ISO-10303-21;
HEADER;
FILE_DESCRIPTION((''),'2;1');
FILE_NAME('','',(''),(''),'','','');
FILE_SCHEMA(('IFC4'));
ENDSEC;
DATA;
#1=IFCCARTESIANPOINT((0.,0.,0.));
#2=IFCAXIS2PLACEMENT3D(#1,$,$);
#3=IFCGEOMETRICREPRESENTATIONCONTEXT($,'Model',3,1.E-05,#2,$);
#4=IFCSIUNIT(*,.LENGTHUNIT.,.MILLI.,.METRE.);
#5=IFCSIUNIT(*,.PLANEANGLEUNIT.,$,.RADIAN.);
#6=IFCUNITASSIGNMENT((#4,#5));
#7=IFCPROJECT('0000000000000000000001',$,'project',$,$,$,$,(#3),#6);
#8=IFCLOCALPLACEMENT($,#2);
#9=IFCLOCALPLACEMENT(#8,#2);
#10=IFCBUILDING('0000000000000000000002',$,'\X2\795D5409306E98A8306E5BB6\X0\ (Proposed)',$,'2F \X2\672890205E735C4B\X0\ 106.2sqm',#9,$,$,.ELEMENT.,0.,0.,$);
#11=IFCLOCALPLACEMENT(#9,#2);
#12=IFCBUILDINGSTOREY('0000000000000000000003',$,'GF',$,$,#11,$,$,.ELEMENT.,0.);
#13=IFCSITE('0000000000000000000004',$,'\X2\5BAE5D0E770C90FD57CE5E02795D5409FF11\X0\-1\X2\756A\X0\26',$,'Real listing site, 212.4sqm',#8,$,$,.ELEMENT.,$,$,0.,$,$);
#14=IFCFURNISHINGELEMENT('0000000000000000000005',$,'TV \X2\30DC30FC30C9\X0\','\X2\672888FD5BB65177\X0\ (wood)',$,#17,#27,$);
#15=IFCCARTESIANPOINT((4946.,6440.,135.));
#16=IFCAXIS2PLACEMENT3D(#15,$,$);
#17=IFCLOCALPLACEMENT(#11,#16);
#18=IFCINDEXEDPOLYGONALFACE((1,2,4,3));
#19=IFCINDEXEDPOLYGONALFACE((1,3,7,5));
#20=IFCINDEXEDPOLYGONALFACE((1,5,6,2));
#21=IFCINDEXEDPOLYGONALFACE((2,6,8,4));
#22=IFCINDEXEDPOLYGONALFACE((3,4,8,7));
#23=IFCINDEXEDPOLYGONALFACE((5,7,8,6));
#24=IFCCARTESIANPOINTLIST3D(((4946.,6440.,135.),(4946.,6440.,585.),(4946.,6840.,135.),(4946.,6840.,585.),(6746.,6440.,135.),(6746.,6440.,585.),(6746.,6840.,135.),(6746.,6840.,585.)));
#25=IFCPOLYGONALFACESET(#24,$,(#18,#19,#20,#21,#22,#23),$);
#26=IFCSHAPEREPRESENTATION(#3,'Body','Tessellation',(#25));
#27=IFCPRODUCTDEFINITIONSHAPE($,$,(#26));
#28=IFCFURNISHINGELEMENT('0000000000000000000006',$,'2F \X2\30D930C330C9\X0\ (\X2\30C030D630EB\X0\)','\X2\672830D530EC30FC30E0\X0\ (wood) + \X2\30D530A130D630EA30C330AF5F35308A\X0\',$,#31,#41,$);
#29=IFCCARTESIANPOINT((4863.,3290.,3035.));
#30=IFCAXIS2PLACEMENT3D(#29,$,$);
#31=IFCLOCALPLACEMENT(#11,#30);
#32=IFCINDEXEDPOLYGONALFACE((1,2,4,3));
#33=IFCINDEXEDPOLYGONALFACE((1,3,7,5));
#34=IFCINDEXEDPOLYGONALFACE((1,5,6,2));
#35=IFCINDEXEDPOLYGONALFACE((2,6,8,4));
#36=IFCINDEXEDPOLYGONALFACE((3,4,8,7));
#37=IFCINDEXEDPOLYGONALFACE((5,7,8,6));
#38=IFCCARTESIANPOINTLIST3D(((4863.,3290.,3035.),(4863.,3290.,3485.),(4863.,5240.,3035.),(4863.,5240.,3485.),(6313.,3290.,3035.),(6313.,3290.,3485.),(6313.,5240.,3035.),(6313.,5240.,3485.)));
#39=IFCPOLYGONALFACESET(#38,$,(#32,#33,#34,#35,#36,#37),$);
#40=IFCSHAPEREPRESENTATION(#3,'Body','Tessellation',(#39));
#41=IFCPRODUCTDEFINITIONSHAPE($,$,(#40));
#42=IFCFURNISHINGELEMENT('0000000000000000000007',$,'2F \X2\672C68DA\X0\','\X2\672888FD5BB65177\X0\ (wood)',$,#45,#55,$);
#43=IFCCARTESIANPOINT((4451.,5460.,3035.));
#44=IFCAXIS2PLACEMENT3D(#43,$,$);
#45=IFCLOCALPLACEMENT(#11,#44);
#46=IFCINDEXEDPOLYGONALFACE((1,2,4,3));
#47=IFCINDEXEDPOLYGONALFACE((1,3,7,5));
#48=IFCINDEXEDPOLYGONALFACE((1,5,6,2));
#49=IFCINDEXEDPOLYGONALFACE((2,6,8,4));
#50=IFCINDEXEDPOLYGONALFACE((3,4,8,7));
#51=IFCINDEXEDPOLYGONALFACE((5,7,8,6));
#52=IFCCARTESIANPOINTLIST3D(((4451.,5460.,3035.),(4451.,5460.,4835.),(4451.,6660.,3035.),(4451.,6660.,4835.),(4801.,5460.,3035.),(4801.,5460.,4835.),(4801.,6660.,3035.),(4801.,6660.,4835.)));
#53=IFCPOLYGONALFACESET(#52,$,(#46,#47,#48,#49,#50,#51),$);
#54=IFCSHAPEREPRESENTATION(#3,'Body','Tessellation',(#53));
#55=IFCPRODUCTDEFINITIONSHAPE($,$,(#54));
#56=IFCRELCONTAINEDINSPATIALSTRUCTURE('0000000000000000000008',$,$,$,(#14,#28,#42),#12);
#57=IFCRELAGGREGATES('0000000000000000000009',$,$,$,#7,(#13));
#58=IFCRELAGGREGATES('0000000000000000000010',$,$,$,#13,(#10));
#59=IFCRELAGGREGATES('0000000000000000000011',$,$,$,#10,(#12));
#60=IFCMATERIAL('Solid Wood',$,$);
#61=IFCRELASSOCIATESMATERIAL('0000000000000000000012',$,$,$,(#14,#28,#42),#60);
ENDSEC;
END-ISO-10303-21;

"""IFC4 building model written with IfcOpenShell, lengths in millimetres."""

from ifc_helpers import new_model, si_unit, frame, frame_2d, origin, place, context, project, spatial, rectangle, extrude, material, element, save


model = new_model("IFC4")

# Units and contexts
model_context = context("Model", 3, precision=1e-05, world=origin())
ifc_project = project(units=[si_unit("LENGTHUNIT", "METRE", prefix="MILLI"), si_unit("PLANEANGLEUNIT", "RADIAN")], contexts=[model_context])

# Site, building, storey
site_placement = place(None, origin())
site = spatial("IfcSite", under=ifc_project, at=site_placement, Name="宮崎県都城市祝吉１-1番26", ObjectType="Real listing site, 212.4sqm", CompositionType="ELEMENT", RefElevation=0.0)
building_placement = place(site_placement, origin())
building = spatial("IfcBuilding", under=site, at=building_placement, Name="祝吉の風の家 (Proposed)", ObjectType="2F 木造平屋 106.2sqm", CompositionType="ELEMENT", ElevationOfRefHeight=0.0, ElevationOfTerrain=0.0)
storey_placement = place(building_placement, origin())
storey = spatial("IfcBuildingStorey", under=building, at=storey_placement, Name="GF", CompositionType="ELEMENT", Elevation=0.0)

# Shared definitions
ifc_material_1 = material(Name="Solid Wood")

# Furnishing elements
furnishing_1_placement = place(storey_placement, frame((4946.0, 6440.0, 135.0)))
element("IfcFurnishingElement", 1, at=furnishing_1_placement, inside=storey, material=ifc_material_1, Name="TV ボード", Description="木製家具 (wood)", context=model_context, shape_type="SweptSolid", body=[
    extrude(rectangle(XDim=1800.0, YDim=400.0, at=frame_2d((900.0, 200.0))), frame((4946.0, 6440.0, 135.0)), (0.0, 0.0, 1.0), 450.0),
])
furnishing_2_placement = place(storey_placement, frame((4863.0, 3290.0, 3035.0)))
element("IfcFurnishingElement", 2, at=furnishing_2_placement, inside=storey, material=ifc_material_1, Name="2F ベッド (ダブル)", Description="木フレーム (wood) + ファブリック張り", context=model_context, shape_type="SweptSolid", body=[
    extrude(rectangle(XDim=1450.0, YDim=1950.0, at=frame_2d((725.0, 975.0))), frame((4863.0, 3290.0, 3035.0)), (0.0, 0.0, 1.0), 450.0),
])
furnishing_3_placement = place(storey_placement, frame((4451.0, 5460.0, 3035.0)))
element("IfcFurnishingElement", 3, at=furnishing_3_placement, inside=storey, material=ifc_material_1, Name="2F 本棚", Description="木製家具 (wood)", context=model_context, shape_type="SweptSolid", body=[
    extrude(rectangle(XDim=350.0, YDim=1200.0, at=frame_2d((175.0, 600.0))), frame((4451.0, 5460.0, 3035.0)), (0.0, 0.0, 1.0), 1800.0),
])

save(model, "model.ifc")
